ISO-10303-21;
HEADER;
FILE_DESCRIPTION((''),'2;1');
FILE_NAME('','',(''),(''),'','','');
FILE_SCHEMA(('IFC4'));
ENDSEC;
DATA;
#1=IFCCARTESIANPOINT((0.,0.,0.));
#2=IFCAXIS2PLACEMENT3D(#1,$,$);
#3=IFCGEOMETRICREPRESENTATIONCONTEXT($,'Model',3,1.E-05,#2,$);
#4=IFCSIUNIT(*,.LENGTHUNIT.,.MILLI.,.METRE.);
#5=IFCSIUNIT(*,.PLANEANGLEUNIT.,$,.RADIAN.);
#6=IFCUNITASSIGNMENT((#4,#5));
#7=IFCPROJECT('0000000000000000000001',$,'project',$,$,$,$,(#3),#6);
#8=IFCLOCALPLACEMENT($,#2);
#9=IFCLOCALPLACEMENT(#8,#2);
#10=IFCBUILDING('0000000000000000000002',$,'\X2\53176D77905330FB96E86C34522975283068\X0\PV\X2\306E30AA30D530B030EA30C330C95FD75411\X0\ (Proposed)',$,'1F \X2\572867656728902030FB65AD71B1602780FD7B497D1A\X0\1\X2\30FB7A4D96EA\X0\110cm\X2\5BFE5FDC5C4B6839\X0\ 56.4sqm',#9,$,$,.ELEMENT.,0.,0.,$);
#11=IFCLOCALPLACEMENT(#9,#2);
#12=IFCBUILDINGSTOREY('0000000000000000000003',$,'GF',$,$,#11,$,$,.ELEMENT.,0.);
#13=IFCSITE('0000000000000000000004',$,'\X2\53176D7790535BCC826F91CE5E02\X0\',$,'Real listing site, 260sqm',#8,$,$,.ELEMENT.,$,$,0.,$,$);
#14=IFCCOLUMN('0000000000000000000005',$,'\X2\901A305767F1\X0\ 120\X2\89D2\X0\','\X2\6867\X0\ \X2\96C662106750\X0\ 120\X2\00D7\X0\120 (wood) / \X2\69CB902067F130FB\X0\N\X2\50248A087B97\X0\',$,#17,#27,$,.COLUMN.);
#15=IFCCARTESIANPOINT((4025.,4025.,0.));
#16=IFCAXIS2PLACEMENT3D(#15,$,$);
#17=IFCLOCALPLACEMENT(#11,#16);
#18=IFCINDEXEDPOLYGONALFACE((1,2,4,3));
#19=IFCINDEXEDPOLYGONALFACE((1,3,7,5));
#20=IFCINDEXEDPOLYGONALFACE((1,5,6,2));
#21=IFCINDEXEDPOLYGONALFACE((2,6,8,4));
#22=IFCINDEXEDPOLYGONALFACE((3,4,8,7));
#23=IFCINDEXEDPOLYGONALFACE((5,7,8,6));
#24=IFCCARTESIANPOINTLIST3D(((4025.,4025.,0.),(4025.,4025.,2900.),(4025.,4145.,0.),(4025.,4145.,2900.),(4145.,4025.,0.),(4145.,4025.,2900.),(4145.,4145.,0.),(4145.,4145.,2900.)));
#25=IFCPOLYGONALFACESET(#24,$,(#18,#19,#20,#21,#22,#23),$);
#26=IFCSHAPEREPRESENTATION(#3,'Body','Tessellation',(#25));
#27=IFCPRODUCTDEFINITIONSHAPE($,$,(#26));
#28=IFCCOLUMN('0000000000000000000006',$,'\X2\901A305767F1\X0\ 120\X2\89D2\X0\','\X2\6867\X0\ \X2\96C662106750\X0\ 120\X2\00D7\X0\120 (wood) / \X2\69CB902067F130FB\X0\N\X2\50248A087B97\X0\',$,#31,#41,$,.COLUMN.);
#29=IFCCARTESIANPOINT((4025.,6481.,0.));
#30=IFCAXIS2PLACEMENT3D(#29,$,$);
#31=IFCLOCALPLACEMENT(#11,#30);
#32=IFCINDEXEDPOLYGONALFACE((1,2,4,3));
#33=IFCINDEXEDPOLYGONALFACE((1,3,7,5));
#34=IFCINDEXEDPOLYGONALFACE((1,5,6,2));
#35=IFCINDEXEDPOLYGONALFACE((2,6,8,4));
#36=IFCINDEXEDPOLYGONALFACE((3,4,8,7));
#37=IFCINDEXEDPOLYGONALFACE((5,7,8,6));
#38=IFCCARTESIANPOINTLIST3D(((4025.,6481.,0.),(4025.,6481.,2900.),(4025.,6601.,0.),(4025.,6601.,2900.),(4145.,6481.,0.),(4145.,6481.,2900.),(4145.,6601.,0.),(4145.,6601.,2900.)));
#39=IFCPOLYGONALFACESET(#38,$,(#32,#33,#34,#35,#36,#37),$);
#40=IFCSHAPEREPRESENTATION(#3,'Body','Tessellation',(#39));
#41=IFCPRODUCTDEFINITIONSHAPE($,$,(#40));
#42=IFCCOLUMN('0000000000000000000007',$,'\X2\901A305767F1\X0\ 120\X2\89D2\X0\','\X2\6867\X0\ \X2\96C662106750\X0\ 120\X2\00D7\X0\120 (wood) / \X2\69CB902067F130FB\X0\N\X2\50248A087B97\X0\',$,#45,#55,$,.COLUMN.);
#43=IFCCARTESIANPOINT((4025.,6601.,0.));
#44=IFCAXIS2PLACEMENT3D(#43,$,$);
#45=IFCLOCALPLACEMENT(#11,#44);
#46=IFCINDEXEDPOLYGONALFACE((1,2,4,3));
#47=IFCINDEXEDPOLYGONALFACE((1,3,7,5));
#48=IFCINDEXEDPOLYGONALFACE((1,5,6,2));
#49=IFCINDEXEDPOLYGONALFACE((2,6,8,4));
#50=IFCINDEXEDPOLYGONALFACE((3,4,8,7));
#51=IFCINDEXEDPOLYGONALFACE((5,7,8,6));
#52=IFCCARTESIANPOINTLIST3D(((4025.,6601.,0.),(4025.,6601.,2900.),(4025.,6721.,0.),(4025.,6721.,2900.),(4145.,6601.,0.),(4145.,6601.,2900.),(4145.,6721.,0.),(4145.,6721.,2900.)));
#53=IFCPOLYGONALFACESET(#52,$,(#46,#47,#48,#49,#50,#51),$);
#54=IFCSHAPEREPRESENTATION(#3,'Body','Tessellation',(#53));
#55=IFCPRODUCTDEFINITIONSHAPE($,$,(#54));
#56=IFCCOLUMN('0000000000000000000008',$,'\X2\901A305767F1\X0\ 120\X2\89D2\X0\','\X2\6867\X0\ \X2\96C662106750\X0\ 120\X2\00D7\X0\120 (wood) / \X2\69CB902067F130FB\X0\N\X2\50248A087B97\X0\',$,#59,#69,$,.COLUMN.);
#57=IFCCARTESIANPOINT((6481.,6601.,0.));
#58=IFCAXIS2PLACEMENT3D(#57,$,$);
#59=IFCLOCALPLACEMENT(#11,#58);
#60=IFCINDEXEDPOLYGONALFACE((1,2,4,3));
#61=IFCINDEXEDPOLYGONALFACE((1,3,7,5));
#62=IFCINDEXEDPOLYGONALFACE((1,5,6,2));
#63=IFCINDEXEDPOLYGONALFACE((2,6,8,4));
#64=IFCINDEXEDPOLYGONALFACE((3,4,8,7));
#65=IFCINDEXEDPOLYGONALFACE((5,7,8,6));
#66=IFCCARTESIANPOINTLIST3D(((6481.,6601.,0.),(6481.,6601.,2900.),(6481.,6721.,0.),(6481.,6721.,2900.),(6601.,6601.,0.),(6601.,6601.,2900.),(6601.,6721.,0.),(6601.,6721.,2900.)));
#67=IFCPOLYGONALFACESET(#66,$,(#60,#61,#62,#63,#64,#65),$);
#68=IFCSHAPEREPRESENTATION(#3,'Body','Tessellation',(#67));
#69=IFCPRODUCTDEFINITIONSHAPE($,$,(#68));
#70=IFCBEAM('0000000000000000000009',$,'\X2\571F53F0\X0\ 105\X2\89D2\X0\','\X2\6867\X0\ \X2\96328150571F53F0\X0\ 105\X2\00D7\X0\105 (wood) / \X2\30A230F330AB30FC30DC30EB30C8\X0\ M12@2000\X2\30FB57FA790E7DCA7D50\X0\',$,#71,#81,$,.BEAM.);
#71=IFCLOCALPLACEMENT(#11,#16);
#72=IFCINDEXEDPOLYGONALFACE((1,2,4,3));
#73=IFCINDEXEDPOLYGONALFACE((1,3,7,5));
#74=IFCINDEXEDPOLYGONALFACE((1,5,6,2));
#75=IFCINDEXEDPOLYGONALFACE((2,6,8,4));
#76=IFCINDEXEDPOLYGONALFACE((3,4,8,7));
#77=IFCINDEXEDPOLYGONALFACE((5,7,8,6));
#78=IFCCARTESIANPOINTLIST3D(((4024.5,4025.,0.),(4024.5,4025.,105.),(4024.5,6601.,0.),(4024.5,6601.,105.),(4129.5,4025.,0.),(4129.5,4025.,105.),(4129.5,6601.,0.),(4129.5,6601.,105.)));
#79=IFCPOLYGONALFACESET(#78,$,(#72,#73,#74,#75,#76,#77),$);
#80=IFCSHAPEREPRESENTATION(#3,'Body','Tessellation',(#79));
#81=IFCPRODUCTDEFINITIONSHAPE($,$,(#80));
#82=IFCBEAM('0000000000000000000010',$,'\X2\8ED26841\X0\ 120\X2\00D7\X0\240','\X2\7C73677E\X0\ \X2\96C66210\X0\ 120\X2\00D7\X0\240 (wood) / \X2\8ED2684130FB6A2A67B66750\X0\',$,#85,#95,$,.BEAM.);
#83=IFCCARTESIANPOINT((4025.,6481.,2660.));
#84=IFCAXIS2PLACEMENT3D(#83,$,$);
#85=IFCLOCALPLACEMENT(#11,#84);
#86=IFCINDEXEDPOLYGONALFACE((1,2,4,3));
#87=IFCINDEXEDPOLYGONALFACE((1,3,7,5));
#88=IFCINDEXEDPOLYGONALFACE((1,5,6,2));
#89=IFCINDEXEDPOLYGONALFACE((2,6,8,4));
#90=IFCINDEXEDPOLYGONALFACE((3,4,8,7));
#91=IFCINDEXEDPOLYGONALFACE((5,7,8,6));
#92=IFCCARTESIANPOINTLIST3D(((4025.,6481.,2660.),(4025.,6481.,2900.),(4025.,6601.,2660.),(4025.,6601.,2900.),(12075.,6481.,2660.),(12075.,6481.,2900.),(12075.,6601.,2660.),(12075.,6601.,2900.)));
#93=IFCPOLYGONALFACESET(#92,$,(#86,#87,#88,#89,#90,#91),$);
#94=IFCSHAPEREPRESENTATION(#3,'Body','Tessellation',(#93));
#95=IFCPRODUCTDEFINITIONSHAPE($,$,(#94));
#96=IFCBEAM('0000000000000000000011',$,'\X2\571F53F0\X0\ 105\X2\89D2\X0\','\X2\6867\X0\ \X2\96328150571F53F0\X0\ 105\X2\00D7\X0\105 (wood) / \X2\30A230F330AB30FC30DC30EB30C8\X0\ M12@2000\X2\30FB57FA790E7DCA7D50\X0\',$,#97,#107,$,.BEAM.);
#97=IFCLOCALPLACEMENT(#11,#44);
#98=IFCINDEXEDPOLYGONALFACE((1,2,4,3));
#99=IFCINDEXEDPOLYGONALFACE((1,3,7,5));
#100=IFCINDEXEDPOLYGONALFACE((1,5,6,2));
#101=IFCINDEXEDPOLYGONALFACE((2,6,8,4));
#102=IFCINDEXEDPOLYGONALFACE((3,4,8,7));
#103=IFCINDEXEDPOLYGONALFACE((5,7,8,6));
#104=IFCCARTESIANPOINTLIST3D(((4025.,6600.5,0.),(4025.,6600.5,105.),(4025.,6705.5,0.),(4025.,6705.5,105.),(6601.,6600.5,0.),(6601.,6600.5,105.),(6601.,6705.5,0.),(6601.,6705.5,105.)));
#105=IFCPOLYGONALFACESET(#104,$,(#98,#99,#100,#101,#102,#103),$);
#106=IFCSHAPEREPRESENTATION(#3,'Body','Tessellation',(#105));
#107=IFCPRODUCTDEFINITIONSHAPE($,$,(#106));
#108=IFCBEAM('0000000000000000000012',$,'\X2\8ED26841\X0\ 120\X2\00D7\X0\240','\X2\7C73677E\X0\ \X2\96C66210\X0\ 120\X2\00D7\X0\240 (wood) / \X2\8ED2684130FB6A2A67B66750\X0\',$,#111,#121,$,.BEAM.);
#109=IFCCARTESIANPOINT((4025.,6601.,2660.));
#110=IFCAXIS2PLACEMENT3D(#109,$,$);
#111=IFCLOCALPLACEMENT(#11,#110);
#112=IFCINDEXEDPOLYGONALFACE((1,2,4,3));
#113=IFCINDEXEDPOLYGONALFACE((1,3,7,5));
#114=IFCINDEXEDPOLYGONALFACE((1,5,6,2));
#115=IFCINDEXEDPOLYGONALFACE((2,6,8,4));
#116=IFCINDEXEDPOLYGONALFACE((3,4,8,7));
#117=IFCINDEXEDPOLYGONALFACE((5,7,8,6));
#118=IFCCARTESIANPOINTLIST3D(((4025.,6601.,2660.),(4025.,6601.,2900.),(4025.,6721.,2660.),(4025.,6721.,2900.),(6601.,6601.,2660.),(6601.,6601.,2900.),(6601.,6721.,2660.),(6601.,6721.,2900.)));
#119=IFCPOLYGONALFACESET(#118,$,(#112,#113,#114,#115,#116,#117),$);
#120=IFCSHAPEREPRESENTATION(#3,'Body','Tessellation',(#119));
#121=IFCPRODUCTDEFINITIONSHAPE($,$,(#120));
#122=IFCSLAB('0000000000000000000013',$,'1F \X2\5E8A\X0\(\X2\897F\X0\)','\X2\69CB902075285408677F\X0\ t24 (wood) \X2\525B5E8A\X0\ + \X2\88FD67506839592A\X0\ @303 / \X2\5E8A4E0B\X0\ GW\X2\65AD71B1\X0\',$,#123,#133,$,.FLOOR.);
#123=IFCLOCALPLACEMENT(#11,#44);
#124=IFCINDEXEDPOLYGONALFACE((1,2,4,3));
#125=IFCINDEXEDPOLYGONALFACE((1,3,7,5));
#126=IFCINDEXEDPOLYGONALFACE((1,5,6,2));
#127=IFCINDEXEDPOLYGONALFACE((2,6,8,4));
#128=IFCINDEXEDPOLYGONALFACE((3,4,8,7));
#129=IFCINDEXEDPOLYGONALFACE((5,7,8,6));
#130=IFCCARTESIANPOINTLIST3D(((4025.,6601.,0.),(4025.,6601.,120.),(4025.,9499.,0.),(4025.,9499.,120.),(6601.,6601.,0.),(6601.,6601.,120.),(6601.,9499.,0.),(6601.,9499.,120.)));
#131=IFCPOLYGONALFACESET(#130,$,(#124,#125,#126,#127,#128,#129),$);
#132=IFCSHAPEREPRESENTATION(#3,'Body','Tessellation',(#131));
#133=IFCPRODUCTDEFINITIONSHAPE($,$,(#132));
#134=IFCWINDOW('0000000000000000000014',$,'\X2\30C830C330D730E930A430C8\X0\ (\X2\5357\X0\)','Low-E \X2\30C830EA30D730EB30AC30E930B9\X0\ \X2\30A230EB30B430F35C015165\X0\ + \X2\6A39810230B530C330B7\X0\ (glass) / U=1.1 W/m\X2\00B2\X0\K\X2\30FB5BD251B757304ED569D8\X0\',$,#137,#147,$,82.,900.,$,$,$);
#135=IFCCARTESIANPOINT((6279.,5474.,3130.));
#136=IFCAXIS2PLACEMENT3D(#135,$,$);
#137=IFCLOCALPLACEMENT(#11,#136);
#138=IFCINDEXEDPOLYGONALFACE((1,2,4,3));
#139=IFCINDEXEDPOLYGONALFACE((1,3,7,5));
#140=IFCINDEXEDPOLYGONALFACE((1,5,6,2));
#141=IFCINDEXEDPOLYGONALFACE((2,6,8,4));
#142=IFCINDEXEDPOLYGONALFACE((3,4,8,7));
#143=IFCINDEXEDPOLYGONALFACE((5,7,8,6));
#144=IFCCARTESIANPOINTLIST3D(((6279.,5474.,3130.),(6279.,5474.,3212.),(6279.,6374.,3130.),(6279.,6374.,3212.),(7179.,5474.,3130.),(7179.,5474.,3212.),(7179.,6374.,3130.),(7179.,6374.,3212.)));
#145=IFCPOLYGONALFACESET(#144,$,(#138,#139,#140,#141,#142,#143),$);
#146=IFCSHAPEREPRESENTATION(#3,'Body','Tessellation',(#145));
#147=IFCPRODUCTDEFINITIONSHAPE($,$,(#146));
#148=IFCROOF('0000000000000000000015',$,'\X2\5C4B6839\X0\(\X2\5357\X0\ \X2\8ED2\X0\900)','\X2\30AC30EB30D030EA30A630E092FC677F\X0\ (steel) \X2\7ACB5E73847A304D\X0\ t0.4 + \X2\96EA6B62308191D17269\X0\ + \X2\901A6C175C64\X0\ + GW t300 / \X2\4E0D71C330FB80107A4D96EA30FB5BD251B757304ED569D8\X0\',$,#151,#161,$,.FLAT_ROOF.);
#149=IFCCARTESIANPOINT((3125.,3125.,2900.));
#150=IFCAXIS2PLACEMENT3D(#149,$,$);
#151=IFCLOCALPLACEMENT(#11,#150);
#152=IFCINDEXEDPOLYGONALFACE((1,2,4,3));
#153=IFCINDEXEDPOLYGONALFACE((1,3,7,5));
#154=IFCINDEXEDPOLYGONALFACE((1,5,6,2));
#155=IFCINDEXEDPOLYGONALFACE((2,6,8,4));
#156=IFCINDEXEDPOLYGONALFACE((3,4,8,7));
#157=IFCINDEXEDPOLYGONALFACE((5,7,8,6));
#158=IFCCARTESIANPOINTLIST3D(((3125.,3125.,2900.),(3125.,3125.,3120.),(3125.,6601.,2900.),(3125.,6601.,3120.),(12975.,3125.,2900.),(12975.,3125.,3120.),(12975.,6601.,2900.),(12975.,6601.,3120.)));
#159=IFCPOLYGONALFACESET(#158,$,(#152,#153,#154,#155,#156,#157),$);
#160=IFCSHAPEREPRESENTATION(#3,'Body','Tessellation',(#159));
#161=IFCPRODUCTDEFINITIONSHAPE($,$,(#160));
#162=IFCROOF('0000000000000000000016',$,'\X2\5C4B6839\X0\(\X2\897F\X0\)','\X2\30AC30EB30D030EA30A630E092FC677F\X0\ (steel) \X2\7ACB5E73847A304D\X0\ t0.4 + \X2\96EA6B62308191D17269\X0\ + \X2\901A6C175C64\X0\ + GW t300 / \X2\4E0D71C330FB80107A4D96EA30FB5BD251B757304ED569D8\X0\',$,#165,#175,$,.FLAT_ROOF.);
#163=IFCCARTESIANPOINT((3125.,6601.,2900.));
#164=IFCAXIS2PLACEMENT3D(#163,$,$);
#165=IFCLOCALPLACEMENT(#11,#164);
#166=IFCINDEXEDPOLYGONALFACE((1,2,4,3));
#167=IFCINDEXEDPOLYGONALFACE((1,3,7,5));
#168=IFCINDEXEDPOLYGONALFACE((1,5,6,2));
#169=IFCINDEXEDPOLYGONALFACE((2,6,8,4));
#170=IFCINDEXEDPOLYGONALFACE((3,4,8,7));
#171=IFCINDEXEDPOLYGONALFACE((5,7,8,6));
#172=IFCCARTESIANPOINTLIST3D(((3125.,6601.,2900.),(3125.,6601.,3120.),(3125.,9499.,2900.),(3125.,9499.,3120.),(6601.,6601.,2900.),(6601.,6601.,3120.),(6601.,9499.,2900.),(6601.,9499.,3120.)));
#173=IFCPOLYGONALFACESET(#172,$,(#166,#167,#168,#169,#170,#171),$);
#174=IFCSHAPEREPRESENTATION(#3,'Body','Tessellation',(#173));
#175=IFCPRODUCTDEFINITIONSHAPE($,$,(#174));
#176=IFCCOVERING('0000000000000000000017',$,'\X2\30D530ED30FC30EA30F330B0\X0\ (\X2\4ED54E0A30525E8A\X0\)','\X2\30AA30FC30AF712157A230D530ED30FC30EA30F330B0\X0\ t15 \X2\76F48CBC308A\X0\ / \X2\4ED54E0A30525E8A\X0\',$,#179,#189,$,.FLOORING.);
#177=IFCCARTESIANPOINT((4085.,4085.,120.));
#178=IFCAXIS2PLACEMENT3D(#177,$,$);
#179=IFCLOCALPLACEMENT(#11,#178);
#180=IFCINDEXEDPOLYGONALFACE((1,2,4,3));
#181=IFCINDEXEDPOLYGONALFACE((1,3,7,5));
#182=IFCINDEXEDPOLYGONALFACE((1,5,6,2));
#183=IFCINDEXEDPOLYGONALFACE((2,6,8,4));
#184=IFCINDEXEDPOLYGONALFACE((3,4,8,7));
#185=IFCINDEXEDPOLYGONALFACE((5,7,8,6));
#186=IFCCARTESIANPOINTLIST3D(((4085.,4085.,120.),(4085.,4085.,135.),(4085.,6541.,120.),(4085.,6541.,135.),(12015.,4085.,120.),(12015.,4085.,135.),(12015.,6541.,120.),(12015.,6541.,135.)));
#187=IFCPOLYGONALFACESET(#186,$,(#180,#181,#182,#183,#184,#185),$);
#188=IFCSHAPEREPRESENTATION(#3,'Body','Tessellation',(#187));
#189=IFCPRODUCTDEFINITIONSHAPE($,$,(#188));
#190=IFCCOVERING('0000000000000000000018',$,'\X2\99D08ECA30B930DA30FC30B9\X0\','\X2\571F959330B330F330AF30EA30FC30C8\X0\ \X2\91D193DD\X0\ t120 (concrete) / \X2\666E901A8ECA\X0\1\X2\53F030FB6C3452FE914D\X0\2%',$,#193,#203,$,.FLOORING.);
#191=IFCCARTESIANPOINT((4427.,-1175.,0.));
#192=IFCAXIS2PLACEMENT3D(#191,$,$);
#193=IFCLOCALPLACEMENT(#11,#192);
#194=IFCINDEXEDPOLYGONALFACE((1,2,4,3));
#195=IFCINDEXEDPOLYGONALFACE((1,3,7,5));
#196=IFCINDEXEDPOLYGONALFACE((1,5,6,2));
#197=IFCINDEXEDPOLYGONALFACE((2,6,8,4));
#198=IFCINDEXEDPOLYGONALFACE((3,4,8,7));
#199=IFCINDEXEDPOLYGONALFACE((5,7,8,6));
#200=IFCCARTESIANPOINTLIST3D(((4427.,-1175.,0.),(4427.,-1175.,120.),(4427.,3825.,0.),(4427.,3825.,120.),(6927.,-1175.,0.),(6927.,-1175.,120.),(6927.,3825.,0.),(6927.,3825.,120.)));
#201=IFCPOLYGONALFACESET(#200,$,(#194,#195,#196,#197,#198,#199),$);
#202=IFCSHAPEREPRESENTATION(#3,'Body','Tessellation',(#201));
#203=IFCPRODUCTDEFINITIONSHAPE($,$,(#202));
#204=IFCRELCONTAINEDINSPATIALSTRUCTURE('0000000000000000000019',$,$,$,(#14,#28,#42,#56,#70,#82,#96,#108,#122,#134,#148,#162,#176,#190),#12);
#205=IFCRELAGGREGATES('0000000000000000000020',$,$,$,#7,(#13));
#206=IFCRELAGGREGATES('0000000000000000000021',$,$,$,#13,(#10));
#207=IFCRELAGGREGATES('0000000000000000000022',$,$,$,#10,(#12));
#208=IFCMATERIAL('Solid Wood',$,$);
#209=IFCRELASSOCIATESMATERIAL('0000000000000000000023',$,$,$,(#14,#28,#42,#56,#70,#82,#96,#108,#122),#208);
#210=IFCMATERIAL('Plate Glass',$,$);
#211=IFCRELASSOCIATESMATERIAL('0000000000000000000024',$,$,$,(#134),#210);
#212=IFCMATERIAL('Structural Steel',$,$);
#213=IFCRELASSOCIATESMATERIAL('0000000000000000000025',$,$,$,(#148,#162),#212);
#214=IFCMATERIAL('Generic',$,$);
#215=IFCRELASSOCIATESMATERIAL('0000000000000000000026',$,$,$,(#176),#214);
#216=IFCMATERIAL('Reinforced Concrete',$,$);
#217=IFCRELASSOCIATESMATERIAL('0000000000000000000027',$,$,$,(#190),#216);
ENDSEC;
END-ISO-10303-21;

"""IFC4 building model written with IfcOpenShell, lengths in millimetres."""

from ifc_helpers import new_model, si_unit, frame, frame_2d, origin, place, context, project, spatial, rectangle, extrude, material, element, save


model = new_model("IFC4")

# Units and contexts
model_context = context("Model", 3, precision=1e-05, world=origin())
ifc_project = project(units=[si_unit("LENGTHUNIT", "METRE", prefix="MILLI"), si_unit("PLANEANGLEUNIT", "RADIAN")], contexts=[model_context])

# Site, building, storey
site_placement = place(None, origin())
site = spatial("IfcSite", under=ifc_project, at=site_placement, Name="北海道富良野市", ObjectType="Real listing site, 260sqm", CompositionType="ELEMENT", RefElevation=0.0)
building_placement = place(site_placement, origin())
building = spatial("IfcBuilding", under=site, at=building_placement, Name="北海道・雨水利用とPVのオフグリッド志向 (Proposed)", ObjectType="1F 在来木造・断熱性能等級1・積雪110cm対応屋根 56.4sqm", CompositionType="ELEMENT", ElevationOfRefHeight=0.0, ElevationOfTerrain=0.0)
storey_placement = place(building_placement, origin())
storey = spatial("IfcBuildingStorey", under=building, at=storey_placement, Name="GF", CompositionType="ELEMENT", Elevation=0.0)

# Columns
ifc_material_1 = material(Name="Solid Wood")
column_1_placement = place(storey_placement, frame((4025.0, 4025.0, 0.0)))
element("IfcColumn", 1, at=column_1_placement, inside=storey, material=ifc_material_1, Name="通し柱 120角", Description="桧 集成材 120×120 (wood) / 構造柱・N値計算", PredefinedType="COLUMN", context=model_context, shape_type="SweptSolid", body=[
    extrude(rectangle(XDim=120.0, YDim=120.0, at=frame_2d((60.0, 60.0))), frame((4025.0, 4025.0, 0.0)), (0.0, 0.0, 1.0), 2900.0),
])
column_2_placement = place(storey_placement, frame((4025.0, 6481.0, 0.0)))
element("IfcColumn", 2, at=column_2_placement, inside=storey, material=ifc_material_1, Name="通し柱 120角", Description="桧 集成材 120×120 (wood) / 構造柱・N値計算", PredefinedType="COLUMN", context=model_context, shape_type="SweptSolid", body=[
    extrude(rectangle(XDim=120.0, YDim=120.0, at=frame_2d((60.0, 60.0))), frame((4025.0, 6481.0, 0.0)), (0.0, 0.0, 1.0), 2900.0),
])
column_3_placement = place(storey_placement, frame((4025.0, 6601.0, 0.0)))
element("IfcColumn", 3, at=column_3_placement, inside=storey, material=ifc_material_1, Name="通し柱 120角", Description="桧 集成材 120×120 (wood) / 構造柱・N値計算", PredefinedType="COLUMN", context=model_context, shape_type="SweptSolid", body=[
    extrude(rectangle(XDim=120.0, YDim=120.0, at=frame_2d((60.0, 60.0))), frame((4025.0, 6601.0, 0.0)), (0.0, 0.0, 1.0), 2900.0),
])
column_4_placement = place(storey_placement, frame((6481.0, 6601.0, 0.0)))
element("IfcColumn", 4, at=column_4_placement, inside=storey, material=ifc_material_1, Name="通し柱 120角", Description="桧 集成材 120×120 (wood) / 構造柱・N値計算", PredefinedType="COLUMN", context=model_context, shape_type="SweptSolid", body=[
    extrude(rectangle(XDim=120.0, YDim=120.0, at=frame_2d((60.0, 60.0))), frame((6481.0, 6601.0, 0.0)), (0.0, 0.0, 1.0), 2900.0),
])

# Beams
beam_1_placement = place(storey_placement, frame((4025.0, 4025.0, 0.0)))
element("IfcBeam", 5, at=beam_1_placement, inside=storey, material=ifc_material_1, Name="土台 105角", Description="桧 防腐土台 105×105 (wood) / アンカーボルト M12@2000・基礎緊結", PredefinedType="BEAM", context=model_context, shape_type="SweptSolid", body=[
    extrude(rectangle(XDim=105.0, YDim=2576.0, at=frame_2d((52.0, 1288.0))), frame((4025.0, 4025.0, 0.0)), (0.0, 0.0, 1.0), 105.0),
])
beam_2_placement = place(storey_placement, frame((4025.0, 6481.0, 2660.0)))
element("IfcBeam", 6, at=beam_2_placement, inside=storey, material=ifc_material_1, Name="軒桁 120×240", Description="米松 集成 120×240 (wood) / 軒桁・横架材", PredefinedType="BEAM", context=model_context, shape_type="SweptSolid", body=[
    extrude(rectangle(XDim=8050.0, YDim=120.0, at=frame_2d((4025.0, 60.0))), frame((4025.0, 6481.0, 2660.0)), (0.0, 0.0, 1.0), 240.0),
])
beam_3_placement = place(storey_placement, frame((4025.0, 6601.0, 0.0)))
element("IfcBeam", 7, at=beam_3_placement, inside=storey, material=ifc_material_1, Name="土台 105角", Description="桧 防腐土台 105×105 (wood) / アンカーボルト M12@2000・基礎緊結", PredefinedType="BEAM", context=model_context, shape_type="SweptSolid", body=[
    extrude(rectangle(XDim=2576.0, YDim=105.0, at=frame_2d((1288.0, 52.0))), frame((4025.0, 6601.0, 0.0)), (0.0, 0.0, 1.0), 105.0),
])
beam_4_placement = place(storey_placement, frame((4025.0, 6601.0, 2660.0)))
element("IfcBeam", 8, at=beam_4_placement, inside=storey, material=ifc_material_1, Name="軒桁 120×240", Description="米松 集成 120×240 (wood) / 軒桁・横架材", PredefinedType="BEAM", context=model_context, shape_type="SweptSolid", body=[
    extrude(rectangle(XDim=2576.0, YDim=120.0, at=frame_2d((1288.0, 60.0))), frame((4025.0, 6601.0, 2660.0)), (0.0, 0.0, 1.0), 240.0),
])

# Slab
ifc_material_2 = material(Name="Reinforced Concrete")
slab_1_placement = place(storey_placement, frame((4025.0, 6601.0, 0.0)))
element("IfcSlab", 9, at=slab_1_placement, inside=storey, material=ifc_material_1, Name="1F 床(西)", Description="構造用合板 t24 (wood) 剛床 + 製材根太 @303 / 床下 GW断熱", PredefinedType="FLOOR", context=model_context, shape_type="SweptSolid", body=[
    extrude(rectangle(XDim=2576.0, YDim=2898.0, at=frame_2d((1288.0, 1449.0))), frame((4025.0, 6601.0, 0.0)), (0.0, 0.0, 1.0), 120.0),
])

# Shared definitions
ifc_material_3 = material(Name="Plate Glass")

# Window
window_1_placement = place(storey_placement, frame((6279.0, 5474.0, 3130.0)))
element("IfcWindow", 10, at=window_1_placement, inside=storey, material=ifc_material_3, Name="トップライト (南)", Description="Low-E トリプルガラス アルゴン封入 + 樹脂サッシ (glass) / U=1.1 W/m²K・寒冷地仕様", OverallHeight=82.0, OverallWidth=900.0, context=model_context, shape_type="SweptSolid", body=[
    extrude(rectangle(XDim=900.0, YDim=900.0, at=frame_2d((450.0, 450.0))), frame((6279.0, 5474.0, 3130.0)), (0.0, 0.0, 1.0), 82.0),
])

# Roofs
ifc_material_4 = material(Name="Structural Steel")
roof_1_placement = place(storey_placement, frame((3125.0, 3125.0, 2900.0)))
element("IfcRoof", 11, at=roof_1_placement, inside=storey, material=ifc_material_4, Name="屋根(南 軒900)", Description="ガルバリウム鋼板 (steel) 立平葺き t0.4 + 雪止め金物 + 通気層 + GW t300 / 不燃・耐積雪・寒冷地仕様", PredefinedType="FLAT_ROOF", context=model_context, shape_type="SweptSolid", body=[
    extrude(rectangle(XDim=9850.0, YDim=3476.0, at=frame_2d((4925.0, 1738.0))), frame((3125.0, 3125.0, 2900.0)), (0.0, 0.0, 1.0), 220.0),
])
roof_2_placement = place(storey_placement, frame((3125.0, 6601.0, 2900.0)))
element("IfcRoof", 12, at=roof_2_placement, inside=storey, material=ifc_material_4, Name="屋根(西)", Description="ガルバリウム鋼板 (steel) 立平葺き t0.4 + 雪止め金物 + 通気層 + GW t300 / 不燃・耐積雪・寒冷地仕様", PredefinedType="FLAT_ROOF", context=model_context, shape_type="SweptSolid", body=[
    extrude(rectangle(XDim=3476.0, YDim=2898.0, at=frame_2d((1738.0, 1449.0))), frame((3125.0, 6601.0, 2900.0)), (0.0, 0.0, 1.0), 220.0),
])

# Coverings
ifc_material_5 = material(Name="Generic")
covering_1_placement = place(storey_placement, frame((4085.0, 4085.0, 120.0)))
element("IfcCovering", 13, at=covering_1_placement, inside=storey, material=ifc_material_5, Name="フローリング (仕上げ床)", Description="オーク無垢フローリング t15 直貼り / 仕上げ床", PredefinedType="FLOORING", context=model_context, shape_type="SweptSolid", body=[
    extrude(rectangle(XDim=7930.0, YDim=2456.0, at=frame_2d((3965.0, 1228.0))), frame((4085.0, 4085.0, 120.0)), (0.0, 0.0, 1.0), 15.0),
])
covering_2_placement = place(storey_placement, frame((4427.0, -1175.0, 0.0)))
element("IfcCovering", 14, at=covering_2_placement, inside=storey, material=ifc_material_2, Name="駐車スペース", Description="土間コンクリート 金鏝 t120 (concrete) / 普通車1台・水勾配2%", PredefinedType="FLOORING", context=model_context, shape_type="SweptSolid", body=[
    extrude(rectangle(XDim=2500.0, YDim=5000.0, at=frame_2d((1250.0, 2500.0))), frame((4427.0, -1175.0, 0.0)), (0.0, 0.0, 1.0), 120.0),
])

save(model, "model.ifc")
